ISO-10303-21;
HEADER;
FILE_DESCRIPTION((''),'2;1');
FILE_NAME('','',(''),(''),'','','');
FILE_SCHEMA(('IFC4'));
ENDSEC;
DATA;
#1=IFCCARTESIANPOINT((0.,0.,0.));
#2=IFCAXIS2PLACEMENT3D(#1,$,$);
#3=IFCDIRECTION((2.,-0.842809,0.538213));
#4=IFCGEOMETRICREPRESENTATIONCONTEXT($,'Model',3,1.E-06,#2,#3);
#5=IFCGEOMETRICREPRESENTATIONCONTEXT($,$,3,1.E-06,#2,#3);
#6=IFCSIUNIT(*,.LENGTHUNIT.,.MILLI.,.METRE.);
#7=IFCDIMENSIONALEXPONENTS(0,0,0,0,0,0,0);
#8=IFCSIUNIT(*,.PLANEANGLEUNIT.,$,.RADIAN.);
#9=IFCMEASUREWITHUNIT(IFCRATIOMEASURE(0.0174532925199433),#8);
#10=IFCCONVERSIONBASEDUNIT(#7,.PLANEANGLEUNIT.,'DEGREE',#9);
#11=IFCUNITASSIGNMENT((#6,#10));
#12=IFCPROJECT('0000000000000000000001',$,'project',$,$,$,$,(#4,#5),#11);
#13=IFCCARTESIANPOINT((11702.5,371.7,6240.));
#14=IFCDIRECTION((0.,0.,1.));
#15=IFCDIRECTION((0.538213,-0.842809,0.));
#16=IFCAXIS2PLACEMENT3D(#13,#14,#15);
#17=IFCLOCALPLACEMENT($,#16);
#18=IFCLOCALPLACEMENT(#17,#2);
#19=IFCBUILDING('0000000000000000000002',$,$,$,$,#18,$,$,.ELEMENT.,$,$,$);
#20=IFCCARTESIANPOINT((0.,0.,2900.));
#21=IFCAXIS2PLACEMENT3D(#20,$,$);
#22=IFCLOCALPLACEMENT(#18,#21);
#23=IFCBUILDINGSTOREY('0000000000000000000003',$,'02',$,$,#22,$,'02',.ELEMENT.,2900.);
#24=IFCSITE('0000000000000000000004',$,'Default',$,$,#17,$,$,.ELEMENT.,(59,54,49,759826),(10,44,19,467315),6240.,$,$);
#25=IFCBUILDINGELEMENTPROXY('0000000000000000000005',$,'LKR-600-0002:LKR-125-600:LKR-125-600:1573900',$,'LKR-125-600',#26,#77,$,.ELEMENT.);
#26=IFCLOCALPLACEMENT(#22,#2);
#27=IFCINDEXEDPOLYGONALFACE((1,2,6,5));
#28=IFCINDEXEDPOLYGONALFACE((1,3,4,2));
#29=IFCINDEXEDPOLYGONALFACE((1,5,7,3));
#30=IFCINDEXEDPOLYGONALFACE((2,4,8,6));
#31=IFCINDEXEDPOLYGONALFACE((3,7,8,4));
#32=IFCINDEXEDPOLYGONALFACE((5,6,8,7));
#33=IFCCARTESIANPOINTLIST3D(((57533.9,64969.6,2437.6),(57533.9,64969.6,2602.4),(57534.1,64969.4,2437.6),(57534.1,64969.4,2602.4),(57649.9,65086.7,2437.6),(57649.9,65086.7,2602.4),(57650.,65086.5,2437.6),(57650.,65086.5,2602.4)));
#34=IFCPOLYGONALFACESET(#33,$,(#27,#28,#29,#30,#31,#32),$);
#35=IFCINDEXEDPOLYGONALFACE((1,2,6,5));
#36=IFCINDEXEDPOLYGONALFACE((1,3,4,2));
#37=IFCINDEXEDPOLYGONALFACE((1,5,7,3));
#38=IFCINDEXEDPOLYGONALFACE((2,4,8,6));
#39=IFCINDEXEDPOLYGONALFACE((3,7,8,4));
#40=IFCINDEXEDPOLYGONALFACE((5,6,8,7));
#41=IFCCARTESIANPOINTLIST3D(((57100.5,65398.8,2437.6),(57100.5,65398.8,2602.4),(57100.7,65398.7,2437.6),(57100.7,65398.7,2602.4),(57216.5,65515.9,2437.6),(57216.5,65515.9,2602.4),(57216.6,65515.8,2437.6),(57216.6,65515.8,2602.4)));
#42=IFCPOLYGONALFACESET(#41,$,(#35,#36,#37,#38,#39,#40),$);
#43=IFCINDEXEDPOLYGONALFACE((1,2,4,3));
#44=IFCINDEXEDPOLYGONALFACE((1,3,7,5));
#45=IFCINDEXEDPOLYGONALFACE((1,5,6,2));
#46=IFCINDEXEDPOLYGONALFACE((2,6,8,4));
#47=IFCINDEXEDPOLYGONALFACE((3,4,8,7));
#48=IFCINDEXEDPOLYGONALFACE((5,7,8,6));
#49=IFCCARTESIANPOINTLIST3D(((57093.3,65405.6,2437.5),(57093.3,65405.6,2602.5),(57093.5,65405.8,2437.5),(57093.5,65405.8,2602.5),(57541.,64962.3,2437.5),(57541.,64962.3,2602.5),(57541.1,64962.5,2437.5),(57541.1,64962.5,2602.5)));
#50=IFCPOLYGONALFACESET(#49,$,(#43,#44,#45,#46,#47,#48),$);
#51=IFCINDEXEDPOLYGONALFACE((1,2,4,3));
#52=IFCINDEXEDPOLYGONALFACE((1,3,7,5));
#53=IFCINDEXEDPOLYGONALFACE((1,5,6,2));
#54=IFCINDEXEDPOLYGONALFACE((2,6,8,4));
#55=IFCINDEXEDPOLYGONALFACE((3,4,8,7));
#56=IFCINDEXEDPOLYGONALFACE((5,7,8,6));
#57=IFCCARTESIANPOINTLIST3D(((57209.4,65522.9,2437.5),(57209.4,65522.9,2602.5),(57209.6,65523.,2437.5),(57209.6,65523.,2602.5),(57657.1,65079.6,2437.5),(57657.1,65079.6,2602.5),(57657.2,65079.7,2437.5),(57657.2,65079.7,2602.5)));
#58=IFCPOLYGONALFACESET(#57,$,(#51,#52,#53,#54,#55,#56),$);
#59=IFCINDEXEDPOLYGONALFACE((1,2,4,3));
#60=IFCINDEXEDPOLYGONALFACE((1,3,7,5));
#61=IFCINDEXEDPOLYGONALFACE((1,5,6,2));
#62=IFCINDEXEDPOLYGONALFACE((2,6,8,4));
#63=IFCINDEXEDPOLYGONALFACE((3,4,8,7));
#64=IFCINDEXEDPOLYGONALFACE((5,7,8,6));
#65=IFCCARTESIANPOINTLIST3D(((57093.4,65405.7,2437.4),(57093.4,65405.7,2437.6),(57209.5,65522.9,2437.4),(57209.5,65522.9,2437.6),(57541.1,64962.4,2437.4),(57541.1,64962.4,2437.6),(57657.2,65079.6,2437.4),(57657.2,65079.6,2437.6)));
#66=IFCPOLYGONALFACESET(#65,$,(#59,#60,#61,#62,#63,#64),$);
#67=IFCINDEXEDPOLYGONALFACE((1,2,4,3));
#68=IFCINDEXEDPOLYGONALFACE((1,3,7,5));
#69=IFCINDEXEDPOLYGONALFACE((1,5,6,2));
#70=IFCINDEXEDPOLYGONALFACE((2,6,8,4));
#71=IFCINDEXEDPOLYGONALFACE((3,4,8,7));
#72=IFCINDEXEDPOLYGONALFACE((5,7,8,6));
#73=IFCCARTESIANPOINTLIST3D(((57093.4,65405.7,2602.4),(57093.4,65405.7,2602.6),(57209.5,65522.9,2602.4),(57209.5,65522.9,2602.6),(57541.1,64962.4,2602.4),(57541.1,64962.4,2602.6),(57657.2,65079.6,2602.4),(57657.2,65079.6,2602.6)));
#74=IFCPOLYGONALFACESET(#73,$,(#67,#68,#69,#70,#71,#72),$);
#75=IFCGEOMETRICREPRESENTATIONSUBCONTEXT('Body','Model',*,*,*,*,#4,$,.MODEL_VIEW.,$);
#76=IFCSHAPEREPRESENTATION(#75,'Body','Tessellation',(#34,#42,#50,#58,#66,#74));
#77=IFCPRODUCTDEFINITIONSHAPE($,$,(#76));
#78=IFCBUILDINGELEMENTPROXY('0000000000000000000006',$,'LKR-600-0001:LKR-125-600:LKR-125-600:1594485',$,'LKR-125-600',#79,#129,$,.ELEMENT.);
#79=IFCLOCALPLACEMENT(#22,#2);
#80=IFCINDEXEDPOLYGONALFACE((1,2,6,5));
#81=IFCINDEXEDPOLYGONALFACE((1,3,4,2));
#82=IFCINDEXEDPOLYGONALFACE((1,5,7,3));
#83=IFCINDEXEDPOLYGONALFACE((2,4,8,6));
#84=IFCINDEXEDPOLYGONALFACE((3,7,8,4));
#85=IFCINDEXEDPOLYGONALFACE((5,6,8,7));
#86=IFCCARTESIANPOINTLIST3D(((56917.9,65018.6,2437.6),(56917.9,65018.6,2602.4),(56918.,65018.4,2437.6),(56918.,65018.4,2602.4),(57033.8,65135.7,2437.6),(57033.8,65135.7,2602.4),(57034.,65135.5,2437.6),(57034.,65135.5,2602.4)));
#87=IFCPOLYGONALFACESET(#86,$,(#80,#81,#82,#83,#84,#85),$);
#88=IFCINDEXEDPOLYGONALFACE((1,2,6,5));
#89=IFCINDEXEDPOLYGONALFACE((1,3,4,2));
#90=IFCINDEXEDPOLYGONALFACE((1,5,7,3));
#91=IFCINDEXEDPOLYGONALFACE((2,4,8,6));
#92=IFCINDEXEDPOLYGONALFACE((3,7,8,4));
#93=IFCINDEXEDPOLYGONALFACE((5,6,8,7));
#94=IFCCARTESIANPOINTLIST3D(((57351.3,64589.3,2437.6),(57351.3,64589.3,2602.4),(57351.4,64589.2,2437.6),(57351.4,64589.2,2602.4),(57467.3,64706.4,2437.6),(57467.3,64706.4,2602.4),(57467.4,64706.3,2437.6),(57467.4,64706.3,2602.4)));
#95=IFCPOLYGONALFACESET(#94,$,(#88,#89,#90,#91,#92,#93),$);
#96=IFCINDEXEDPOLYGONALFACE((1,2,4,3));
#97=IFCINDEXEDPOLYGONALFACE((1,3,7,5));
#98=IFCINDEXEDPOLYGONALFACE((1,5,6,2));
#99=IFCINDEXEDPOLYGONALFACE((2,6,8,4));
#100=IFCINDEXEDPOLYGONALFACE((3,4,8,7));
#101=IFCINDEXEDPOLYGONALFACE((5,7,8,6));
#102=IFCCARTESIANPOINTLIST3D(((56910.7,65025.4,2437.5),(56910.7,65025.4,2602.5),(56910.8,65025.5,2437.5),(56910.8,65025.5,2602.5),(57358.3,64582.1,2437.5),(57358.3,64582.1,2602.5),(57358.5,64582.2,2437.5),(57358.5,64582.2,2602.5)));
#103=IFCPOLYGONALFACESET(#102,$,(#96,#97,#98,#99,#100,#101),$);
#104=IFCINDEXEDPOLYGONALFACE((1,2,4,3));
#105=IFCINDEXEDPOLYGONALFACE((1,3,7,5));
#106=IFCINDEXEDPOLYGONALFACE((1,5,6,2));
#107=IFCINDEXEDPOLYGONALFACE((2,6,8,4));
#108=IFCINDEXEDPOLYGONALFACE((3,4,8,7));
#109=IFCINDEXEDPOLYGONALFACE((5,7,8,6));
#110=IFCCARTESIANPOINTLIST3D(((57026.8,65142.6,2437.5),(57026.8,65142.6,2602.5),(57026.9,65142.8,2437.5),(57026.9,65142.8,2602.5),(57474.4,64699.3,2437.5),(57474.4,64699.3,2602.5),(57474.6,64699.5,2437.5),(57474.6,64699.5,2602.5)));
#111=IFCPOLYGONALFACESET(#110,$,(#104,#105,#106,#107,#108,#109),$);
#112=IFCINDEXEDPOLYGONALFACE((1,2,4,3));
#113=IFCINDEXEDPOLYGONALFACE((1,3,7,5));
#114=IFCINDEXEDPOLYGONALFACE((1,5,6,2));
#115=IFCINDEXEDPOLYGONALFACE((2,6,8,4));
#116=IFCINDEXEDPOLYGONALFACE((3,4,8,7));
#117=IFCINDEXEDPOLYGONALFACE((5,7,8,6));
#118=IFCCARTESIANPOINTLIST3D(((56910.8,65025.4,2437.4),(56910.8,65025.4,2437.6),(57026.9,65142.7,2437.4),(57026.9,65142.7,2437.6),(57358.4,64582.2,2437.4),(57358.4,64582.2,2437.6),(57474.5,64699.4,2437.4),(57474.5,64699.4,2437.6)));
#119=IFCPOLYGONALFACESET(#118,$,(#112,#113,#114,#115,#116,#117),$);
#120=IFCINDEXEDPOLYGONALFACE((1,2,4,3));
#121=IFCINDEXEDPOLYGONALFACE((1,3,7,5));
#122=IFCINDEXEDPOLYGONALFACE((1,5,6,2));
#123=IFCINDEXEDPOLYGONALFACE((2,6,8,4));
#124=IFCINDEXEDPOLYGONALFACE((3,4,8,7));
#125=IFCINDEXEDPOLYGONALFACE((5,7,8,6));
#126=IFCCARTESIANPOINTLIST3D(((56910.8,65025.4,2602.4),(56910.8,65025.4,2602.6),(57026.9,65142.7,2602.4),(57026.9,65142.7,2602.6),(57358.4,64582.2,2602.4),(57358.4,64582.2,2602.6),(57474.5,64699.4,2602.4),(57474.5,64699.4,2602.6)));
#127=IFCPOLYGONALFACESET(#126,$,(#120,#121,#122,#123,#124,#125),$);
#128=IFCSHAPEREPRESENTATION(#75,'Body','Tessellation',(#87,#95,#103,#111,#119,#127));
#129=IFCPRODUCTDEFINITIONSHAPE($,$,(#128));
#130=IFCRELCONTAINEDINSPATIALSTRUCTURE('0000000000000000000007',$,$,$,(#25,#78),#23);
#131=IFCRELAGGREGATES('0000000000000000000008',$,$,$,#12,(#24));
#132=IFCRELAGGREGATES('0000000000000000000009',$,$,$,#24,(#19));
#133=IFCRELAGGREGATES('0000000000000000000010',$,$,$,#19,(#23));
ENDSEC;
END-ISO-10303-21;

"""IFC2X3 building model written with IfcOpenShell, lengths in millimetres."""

from ifc_helpers import new_model, entity, si_unit, converted_unit, direction, frame, frame_2d, origin, place, context, subcontext, project, spatial, rectangle, extrude, source, transform, mapped, element, save


model = new_model("IFC2X3")

# Units and contexts
model_context = context("Model", 3, precision=1e-06, world=origin(), true_north=direction((2.0, -0.842809, 0.538213)))
context_of_model = context(None, 3, precision=1e-06, world=origin(), true_north=direction((2.0, -0.842809, 0.538213)))
body_context = subcontext(model_context, "Body", "Model", "MODEL_VIEW")
ifc_project = project(units=[si_unit("LENGTHUNIT", "METRE", prefix="MILLI"), converted_unit("PLANEANGLEUNIT", "DEGREE", entity("IfcRatioMeasure", 0.0174532925199433), si_unit("PLANEANGLEUNIT", "RADIAN"), dimensions=[0, 0, 0, 0, 0, 0, 0])], contexts=[model_context, context_of_model])

# Site, building, storey
site_placement = place(None, frame((11702.5, 371.7, 6240.0), z_axis=(0.0, 0.0, 1.0), x_axis=(0.538213, -0.842809, 0.0)))
site = spatial("IfcSite", under=ifc_project, at=site_placement, Name="Default", CompositionType="ELEMENT", RefLatitude=(59, 54, 49, 759826), RefLongitude=(10, 44, 19, 467315), RefElevation=6240.0)
building_placement = place(site_placement, origin())
building = spatial("IfcBuilding", under=site, at=building_placement, CompositionType="ELEMENT")
storey_placement = place(building_placement, frame((0.0, 0.0, 2900.0)))
storey = spatial("IfcBuildingStorey", under=building, at=storey_placement, Name="02", LongName="02", CompositionType="ELEMENT", Elevation=2900.0)

# Building element proxies
shared_shape_1 = source(origin(), body_context, "Body", "SweptSolid", [
    extrude(rectangle(XDim=164.8, YDim=0.2, at=frame_2d((0.0, 0.0), x_axis=(1.0, 0.0))), frame((305.0, 0.0, -82.4), z_axis=(0.0, 0.0, 1.0), x_axis=(0.0, -1.0, 0.0)), (0.0, 0.0, 1.0), 164.8),
    extrude(rectangle(XDim=164.8, YDim=0.2, at=frame_2d((0.0, 0.0), x_axis=(1.0, 0.0))), frame((-305.0, 0.0, -82.4), z_axis=(0.0, 0.0, 1.0), x_axis=(0.0, -1.0, 0.0)), (0.0, 0.0, 1.0), 164.8),
    extrude(rectangle(XDim=630.0, YDim=0.2, at=frame_2d((0.0, 0.0), x_axis=(1.0, 0.0))), frame((0.0, -82.5, -82.5), z_axis=(0.0, 0.0, 1.0), x_axis=(-1.0, 0.0, 0.0)), (0.0, 0.0, 1.0), 165.0),
    extrude(rectangle(XDim=630.0, YDim=0.2, at=frame_2d((0.0, 0.0), x_axis=(1.0, 0.0))), frame((0.0, 82.5, -82.5), z_axis=(0.0, 0.0, 1.0), x_axis=(-1.0, 0.0, 0.0)), (0.0, 0.0, 1.0), 165.0),
    extrude(rectangle(XDim=630.0, YDim=165.0, at=frame_2d((0.0, 0.0), x_axis=(1.0, 0.0))), frame((0.0, 0.0, -82.6)), (0.0, 0.0, 1.0), 0.2),
    extrude(rectangle(XDim=630.0, YDim=165.0, at=frame_2d((0.0, 0.0), x_axis=(1.0, 0.0))), frame((0.0, 0.0, 82.4)), (0.0, 0.0, 1.0), 0.2),
])
proxy_1_placement = place(storey_placement, frame((57375.3, 65242.7, 2520.0), z_axis=(0.0, 0.0, 1.0), x_axis=(0.710554, -0.703643, 0.0)))
element("IfcBuildingElementProxy", 1, at=proxy_1_placement, inside=storey, Name="LKR-600-0002:LKR-125-600:LKR-125-600:1573900", ObjectType="LKR-125-600", CompositionType="ELEMENT", context=body_context, shape_type="MappedRepresentation", body=[
    mapped(shared_shape_1, transform((0.0, 0.0, 0.0), scale=1.0)),
])
shared_shape_2 = source(origin(), body_context, "Body", "SweptSolid", [
    extrude(rectangle(XDim=0.2, YDim=164.8, at=frame_2d((0.0, 0.0), x_axis=(1.0, 0.0))), frame((305.0, 0.0, -82.4)), (0.0, 0.0, 1.0), 164.8),
    extrude(rectangle(XDim=0.2, YDim=164.8, at=frame_2d((0.0, 0.0), x_axis=(1.0, 0.0))), frame((-305.0, 0.0, -82.4)), (0.0, 0.0, 1.0), 164.8),
    extrude(rectangle(XDim=0.2, YDim=630.0, at=frame_2d((0.0, 0.0), x_axis=(1.0, 0.0))), frame((0.0, 82.5, -82.5), z_axis=(0.0, 0.0, 1.0), x_axis=(0.0, 1.0, 0.0)), (0.0, 0.0, 1.0), 165.0),
    extrude(rectangle(XDim=0.2, YDim=630.0, at=frame_2d((0.0, 0.0), x_axis=(1.0, 0.0))), frame((0.0, -82.5, -82.5), z_axis=(0.0, 0.0, 1.0), x_axis=(0.0, 1.0, 0.0)), (0.0, 0.0, 1.0), 165.0),
    extrude(rectangle(XDim=165.0, YDim=630.0, at=frame_2d((0.0, 0.0), x_axis=(1.0, 0.0))), frame((0.0, 0.0, -82.6), z_axis=(0.0, 0.0, 1.0), x_axis=(0.0, -1.0, 0.0)), (0.0, 0.0, 1.0), 0.2),
    extrude(rectangle(XDim=165.0, YDim=630.0, at=frame_2d((0.0, 0.0), x_axis=(1.0, 0.0))), frame((0.0, 0.0, 82.4), z_axis=(0.0, 0.0, 1.0), x_axis=(0.0, -1.0, 0.0)), (0.0, 0.0, 1.0), 0.2),
])
proxy_2_placement = place(storey_placement, frame((57192.6, 64862.4, 2520.0), z_axis=(0.0, 0.0, 1.0), x_axis=(-0.710554, 0.703643, 0.0)))
element("IfcBuildingElementProxy", 2, at=proxy_2_placement, inside=storey, Name="LKR-600-0001:LKR-125-600:LKR-125-600:1594485", ObjectType="LKR-125-600", CompositionType="ELEMENT", context=body_context, shape_type="MappedRepresentation", body=[
    mapped(shared_shape_2, transform((0.0, 0.0, 0.0), scale=1.0)),
])

save(model, "model.ifc")
